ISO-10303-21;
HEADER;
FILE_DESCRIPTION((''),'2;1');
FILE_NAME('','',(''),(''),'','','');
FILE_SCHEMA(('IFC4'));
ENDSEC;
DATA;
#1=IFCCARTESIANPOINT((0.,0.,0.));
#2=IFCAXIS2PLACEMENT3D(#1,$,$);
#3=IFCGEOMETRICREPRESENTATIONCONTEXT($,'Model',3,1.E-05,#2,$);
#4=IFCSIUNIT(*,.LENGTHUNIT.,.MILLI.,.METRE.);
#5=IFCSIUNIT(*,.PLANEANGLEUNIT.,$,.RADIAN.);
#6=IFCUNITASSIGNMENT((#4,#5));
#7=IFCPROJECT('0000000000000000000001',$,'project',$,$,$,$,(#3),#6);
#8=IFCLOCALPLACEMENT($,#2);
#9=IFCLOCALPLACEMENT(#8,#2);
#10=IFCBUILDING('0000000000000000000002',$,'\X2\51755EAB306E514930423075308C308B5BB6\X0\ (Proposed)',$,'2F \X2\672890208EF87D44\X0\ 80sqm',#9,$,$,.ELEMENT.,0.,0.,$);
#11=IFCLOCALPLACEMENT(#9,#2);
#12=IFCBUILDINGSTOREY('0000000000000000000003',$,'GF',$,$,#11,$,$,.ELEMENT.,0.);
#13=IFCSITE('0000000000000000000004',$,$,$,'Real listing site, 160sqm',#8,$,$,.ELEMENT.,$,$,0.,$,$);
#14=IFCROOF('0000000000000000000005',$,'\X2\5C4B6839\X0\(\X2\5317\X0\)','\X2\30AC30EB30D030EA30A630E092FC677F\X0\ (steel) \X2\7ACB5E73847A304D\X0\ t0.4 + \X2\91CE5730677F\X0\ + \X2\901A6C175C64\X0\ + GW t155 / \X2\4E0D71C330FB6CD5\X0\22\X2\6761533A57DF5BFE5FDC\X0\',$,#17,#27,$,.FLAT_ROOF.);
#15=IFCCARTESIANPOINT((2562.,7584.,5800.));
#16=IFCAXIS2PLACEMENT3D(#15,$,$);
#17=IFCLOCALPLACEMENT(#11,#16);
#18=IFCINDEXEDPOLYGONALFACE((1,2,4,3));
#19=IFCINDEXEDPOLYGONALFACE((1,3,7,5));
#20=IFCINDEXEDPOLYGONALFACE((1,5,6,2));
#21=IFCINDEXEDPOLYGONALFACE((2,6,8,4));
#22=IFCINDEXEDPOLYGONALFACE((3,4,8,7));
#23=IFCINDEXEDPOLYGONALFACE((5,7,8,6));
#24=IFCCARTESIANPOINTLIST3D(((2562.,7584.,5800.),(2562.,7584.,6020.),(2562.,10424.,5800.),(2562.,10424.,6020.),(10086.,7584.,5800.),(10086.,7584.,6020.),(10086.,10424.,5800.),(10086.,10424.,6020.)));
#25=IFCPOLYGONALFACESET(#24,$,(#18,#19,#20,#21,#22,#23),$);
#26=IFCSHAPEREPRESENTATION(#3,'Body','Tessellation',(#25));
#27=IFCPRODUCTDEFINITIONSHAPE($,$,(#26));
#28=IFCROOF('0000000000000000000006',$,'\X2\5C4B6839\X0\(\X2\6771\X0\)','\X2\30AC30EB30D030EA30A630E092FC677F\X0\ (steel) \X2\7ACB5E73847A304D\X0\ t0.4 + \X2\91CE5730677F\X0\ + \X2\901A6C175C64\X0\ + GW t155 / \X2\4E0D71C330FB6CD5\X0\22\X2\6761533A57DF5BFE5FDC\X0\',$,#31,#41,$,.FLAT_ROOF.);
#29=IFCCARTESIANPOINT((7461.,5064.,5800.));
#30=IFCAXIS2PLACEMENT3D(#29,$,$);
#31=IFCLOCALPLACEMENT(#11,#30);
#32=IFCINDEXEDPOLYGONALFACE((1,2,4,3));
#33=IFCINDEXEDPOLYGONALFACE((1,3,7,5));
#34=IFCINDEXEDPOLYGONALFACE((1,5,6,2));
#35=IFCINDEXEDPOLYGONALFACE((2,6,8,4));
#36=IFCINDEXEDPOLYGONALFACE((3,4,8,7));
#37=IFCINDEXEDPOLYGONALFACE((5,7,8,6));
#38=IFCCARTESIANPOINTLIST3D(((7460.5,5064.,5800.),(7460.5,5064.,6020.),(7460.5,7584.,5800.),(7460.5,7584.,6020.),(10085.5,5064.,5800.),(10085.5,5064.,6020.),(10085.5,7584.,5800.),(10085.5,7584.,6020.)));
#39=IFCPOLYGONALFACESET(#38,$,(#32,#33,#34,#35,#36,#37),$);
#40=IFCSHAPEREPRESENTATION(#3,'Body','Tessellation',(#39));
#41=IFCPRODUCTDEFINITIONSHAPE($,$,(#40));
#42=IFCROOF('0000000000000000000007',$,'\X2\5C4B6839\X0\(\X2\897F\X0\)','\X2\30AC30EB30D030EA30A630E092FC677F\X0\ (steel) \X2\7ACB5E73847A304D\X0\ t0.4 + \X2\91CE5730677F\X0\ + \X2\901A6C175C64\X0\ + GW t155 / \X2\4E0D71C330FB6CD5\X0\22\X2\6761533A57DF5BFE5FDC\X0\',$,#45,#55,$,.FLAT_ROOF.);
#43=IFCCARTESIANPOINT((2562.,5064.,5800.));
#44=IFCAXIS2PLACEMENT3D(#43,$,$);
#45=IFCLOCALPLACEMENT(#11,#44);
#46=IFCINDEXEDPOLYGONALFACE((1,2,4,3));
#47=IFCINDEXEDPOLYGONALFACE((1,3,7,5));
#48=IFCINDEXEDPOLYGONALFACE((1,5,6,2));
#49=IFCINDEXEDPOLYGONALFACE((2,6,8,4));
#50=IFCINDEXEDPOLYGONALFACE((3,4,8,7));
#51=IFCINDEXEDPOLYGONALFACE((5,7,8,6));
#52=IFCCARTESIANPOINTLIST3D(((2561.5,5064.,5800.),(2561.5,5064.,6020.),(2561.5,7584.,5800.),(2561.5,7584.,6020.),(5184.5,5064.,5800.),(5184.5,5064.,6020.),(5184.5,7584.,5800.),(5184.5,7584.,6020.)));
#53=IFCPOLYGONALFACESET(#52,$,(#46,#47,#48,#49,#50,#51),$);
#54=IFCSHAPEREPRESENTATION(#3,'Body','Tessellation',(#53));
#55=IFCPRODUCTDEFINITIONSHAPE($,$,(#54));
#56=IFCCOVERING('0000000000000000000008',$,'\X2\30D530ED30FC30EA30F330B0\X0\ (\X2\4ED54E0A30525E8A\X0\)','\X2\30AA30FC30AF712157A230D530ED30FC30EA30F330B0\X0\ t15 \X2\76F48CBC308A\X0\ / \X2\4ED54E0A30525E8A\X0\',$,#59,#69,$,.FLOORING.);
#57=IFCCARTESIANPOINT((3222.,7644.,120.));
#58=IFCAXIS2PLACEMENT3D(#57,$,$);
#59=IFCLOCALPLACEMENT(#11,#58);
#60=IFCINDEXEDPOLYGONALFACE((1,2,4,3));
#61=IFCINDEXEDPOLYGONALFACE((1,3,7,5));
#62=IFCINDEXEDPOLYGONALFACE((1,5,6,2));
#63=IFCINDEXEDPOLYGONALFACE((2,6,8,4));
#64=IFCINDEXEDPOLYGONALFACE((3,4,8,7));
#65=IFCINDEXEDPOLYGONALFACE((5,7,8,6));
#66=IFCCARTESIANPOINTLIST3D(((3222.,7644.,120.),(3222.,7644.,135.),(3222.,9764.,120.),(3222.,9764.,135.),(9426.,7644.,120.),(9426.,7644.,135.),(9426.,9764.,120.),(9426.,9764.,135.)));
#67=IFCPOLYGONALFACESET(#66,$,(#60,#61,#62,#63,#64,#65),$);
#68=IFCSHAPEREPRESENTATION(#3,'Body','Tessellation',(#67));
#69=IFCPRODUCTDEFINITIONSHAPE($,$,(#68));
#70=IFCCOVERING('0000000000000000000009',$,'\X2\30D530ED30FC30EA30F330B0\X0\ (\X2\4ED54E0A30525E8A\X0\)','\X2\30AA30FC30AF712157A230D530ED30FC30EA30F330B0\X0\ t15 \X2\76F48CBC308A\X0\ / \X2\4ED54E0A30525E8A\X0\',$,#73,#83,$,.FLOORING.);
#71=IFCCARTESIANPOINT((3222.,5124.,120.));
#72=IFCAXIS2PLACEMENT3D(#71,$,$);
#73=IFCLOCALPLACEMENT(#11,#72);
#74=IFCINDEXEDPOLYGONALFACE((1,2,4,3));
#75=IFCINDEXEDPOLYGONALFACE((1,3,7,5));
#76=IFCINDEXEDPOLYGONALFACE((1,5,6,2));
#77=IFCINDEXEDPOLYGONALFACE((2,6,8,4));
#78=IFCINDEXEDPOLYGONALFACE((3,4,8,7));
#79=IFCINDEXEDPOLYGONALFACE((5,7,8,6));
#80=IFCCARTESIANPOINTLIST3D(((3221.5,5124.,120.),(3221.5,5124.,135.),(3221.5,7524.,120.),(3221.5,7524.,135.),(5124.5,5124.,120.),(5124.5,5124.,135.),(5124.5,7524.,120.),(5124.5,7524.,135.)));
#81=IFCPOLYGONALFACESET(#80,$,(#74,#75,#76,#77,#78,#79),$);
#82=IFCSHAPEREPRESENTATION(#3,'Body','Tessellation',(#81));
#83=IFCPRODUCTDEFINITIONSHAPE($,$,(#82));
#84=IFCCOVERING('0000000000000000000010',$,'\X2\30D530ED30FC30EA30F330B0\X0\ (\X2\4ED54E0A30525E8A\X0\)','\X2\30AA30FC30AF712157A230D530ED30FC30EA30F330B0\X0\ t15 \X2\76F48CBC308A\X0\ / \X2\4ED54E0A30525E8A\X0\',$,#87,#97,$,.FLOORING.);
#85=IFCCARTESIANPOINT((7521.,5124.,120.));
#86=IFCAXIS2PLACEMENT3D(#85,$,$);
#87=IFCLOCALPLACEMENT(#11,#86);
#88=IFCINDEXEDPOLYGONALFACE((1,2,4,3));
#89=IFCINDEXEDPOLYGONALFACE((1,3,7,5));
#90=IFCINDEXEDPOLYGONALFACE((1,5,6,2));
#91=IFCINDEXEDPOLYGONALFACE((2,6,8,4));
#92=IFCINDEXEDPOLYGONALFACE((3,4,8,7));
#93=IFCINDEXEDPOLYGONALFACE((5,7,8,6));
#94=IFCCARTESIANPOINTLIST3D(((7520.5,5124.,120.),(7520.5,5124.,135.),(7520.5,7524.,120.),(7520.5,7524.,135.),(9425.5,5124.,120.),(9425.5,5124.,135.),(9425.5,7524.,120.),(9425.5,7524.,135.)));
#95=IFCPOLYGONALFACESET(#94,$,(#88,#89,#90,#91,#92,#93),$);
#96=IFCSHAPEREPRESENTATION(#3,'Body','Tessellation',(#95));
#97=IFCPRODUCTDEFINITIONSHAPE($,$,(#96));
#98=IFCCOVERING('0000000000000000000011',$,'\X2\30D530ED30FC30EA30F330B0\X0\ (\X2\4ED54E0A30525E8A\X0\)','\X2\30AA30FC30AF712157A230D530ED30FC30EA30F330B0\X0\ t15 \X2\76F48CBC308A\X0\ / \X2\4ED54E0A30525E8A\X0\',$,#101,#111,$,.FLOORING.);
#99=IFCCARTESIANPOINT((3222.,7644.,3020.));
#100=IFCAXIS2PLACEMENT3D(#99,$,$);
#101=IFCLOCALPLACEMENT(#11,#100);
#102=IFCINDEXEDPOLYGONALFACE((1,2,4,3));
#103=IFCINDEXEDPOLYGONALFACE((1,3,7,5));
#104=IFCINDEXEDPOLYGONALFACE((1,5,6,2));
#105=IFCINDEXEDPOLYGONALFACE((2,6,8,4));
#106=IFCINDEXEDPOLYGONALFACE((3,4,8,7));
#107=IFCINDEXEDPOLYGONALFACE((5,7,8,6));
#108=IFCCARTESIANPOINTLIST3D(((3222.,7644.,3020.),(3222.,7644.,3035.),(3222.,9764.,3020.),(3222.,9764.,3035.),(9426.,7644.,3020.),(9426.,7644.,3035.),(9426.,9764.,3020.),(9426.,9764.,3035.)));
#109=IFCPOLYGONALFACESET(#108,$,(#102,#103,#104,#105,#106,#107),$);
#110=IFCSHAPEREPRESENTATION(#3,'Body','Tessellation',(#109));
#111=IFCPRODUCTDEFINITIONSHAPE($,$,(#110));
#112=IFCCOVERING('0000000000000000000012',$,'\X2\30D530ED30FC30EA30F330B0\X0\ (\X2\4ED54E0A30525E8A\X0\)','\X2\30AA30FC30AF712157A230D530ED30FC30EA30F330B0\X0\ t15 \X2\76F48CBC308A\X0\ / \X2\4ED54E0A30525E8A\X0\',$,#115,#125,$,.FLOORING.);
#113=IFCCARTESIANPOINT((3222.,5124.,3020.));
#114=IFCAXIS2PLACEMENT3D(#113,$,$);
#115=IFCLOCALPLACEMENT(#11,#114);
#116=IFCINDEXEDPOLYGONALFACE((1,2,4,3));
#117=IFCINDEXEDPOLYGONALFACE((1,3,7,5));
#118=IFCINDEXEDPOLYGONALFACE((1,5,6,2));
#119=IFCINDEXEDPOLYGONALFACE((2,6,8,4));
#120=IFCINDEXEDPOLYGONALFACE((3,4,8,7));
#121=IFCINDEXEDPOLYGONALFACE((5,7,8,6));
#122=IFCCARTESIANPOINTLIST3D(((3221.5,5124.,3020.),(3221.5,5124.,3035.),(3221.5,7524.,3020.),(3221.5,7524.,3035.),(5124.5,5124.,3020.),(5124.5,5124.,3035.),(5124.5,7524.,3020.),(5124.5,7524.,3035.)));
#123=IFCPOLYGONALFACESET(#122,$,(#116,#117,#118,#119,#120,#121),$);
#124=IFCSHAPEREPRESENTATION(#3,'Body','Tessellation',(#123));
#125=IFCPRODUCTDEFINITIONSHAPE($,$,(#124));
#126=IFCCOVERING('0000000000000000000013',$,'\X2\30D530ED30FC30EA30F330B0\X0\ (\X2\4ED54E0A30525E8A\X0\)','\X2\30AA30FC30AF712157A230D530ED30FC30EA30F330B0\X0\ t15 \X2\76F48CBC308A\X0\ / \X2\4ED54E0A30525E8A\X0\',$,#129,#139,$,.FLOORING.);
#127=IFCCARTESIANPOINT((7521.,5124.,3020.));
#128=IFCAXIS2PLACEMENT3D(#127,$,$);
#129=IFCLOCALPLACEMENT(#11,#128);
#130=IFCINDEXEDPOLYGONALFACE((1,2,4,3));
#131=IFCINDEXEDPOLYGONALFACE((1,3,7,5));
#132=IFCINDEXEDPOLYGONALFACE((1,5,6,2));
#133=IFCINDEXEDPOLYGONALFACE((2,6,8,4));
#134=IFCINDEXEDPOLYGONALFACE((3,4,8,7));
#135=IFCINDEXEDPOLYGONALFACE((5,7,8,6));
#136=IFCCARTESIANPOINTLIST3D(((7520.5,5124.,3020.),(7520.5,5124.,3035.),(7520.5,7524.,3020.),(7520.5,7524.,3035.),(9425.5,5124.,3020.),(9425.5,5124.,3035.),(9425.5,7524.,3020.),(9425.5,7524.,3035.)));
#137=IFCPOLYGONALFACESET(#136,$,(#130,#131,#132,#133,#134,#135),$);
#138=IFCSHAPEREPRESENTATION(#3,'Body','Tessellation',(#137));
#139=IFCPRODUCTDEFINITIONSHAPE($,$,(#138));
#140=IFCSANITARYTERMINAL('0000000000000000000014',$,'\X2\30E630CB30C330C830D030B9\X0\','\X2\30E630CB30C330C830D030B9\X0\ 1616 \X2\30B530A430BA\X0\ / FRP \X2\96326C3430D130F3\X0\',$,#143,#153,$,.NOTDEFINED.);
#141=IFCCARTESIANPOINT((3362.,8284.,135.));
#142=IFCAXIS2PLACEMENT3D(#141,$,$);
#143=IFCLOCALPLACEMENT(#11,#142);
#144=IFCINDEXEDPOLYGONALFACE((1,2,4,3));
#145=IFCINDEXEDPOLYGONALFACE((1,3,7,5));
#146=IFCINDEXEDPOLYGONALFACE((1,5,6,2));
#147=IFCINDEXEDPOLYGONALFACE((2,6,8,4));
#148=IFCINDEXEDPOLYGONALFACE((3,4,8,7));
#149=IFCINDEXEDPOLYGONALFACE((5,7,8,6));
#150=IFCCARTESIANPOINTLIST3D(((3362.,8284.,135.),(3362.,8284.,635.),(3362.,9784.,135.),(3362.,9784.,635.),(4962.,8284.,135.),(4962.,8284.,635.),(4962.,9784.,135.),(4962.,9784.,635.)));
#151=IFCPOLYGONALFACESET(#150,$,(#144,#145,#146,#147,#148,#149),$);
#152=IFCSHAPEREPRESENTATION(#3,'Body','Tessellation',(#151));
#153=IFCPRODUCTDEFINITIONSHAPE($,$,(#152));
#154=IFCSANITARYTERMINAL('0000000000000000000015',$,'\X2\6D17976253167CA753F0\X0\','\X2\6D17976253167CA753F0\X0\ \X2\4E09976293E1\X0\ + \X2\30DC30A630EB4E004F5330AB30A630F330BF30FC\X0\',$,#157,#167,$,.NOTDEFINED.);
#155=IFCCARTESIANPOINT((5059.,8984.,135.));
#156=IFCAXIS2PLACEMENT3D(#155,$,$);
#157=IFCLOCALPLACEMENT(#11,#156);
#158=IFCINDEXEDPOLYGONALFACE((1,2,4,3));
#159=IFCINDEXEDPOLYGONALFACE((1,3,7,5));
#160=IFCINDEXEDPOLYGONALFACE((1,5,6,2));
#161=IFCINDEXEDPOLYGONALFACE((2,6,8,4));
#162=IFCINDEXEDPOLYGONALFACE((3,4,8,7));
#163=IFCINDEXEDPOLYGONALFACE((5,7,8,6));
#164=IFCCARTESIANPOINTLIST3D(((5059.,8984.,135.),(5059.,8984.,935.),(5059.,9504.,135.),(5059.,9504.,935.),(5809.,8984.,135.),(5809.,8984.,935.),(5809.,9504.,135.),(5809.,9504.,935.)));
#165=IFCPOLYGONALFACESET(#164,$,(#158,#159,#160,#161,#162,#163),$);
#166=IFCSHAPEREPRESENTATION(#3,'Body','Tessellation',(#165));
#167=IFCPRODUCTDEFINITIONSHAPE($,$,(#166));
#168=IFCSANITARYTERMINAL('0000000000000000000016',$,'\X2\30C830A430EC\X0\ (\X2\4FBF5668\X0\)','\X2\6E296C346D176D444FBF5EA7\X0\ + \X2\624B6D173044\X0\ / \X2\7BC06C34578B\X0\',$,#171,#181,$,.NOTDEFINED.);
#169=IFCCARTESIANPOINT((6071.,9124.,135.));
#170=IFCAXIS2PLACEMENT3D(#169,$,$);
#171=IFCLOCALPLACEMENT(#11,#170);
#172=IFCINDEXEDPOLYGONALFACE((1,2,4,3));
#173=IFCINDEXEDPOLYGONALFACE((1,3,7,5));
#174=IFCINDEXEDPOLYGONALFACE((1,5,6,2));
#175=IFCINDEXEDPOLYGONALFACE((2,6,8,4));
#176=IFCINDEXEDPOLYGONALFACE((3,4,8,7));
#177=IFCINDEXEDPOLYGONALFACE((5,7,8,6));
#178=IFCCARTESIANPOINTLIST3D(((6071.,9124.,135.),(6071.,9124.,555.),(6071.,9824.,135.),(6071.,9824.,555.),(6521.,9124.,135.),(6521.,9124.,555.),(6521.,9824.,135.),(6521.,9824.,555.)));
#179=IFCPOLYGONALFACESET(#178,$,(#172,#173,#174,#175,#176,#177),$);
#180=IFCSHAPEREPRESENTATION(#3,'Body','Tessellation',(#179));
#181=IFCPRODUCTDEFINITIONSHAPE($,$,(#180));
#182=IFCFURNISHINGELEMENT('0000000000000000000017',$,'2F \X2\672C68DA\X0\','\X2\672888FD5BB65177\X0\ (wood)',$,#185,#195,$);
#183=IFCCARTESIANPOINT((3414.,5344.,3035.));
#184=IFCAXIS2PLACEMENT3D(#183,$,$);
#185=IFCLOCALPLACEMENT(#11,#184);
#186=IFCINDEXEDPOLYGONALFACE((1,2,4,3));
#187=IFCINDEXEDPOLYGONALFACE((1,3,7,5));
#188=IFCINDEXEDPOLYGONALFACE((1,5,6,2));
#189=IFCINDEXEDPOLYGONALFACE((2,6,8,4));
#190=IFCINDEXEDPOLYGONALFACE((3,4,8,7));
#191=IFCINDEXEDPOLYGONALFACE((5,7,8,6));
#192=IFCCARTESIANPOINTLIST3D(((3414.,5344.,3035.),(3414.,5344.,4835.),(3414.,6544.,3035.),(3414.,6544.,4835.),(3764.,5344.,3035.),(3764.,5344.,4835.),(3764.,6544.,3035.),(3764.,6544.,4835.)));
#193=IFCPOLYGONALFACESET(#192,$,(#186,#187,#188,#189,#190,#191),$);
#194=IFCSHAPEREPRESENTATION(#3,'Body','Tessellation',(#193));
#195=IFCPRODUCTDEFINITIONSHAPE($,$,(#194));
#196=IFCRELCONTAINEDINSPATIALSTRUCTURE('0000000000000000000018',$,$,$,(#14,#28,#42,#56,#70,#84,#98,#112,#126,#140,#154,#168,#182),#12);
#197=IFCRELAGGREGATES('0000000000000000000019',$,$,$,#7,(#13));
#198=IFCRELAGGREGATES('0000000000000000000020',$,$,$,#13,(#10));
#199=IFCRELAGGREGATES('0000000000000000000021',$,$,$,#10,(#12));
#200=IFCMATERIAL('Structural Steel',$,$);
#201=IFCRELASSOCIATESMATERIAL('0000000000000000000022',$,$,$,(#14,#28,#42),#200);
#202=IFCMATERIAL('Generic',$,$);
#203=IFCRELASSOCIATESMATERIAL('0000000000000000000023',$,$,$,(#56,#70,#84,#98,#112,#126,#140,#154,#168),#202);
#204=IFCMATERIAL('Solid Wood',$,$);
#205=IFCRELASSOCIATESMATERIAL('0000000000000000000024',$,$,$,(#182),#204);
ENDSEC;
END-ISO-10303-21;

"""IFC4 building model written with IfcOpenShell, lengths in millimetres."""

from ifc_helpers import new_model, si_unit, frame, frame_2d, origin, place, context, project, spatial, rectangle, extrude, material, element, save


model = new_model("IFC4")

# Units and contexts
model_context = context("Model", 3, precision=1e-05, world=origin())
ifc_project = project(units=[si_unit("LENGTHUNIT", "METRE", prefix="MILLI"), si_unit("PLANEANGLEUNIT", "RADIAN")], contexts=[model_context])

# Site, building, storey
site_placement = place(None, origin())
site = spatial("IfcSite", under=ifc_project, at=site_placement, ObjectType="Real listing site, 160sqm", CompositionType="ELEMENT", RefElevation=0.0)
building_placement = place(site_placement, origin())
building = spatial("IfcBuilding", under=site, at=building_placement, Name="兵庫の光あふれる家 (Proposed)", ObjectType="2F 木造軸組 80sqm", CompositionType="ELEMENT", ElevationOfRefHeight=0.0, ElevationOfTerrain=0.0)
storey_placement = place(building_placement, origin())
storey = spatial("IfcBuildingStorey", under=building, at=storey_placement, Name="GF", CompositionType="ELEMENT", Elevation=0.0)

# Shared definitions
ifc_material_1 = material(Name="Solid Wood")

# Roofs
ifc_material_2 = material(Name="Structural Steel")
roof_1_placement = place(storey_placement, frame((2562.0, 7584.0, 5800.0)))
element("IfcRoof", 1, at=roof_1_placement, inside=storey, material=ifc_material_2, Name="屋根(北)", Description="ガルバリウム鋼板 (steel) 立平葺き t0.4 + 野地板 + 通気層 + GW t155 / 不燃・法22条区域対応", PredefinedType="FLAT_ROOF", context=model_context, shape_type="SweptSolid", body=[
    extrude(rectangle(XDim=7524.0, YDim=2840.0, at=frame_2d((3762.0, 1420.0))), frame((2562.0, 7584.0, 5800.0)), (0.0, 0.0, 1.0), 220.0),
])
roof_2_placement = place(storey_placement, frame((7461.0, 5064.0, 5800.0)))
element("IfcRoof", 2, at=roof_2_placement, inside=storey, material=ifc_material_2, Name="屋根(東)", Description="ガルバリウム鋼板 (steel) 立平葺き t0.4 + 野地板 + 通気層 + GW t155 / 不燃・法22条区域対応", PredefinedType="FLAT_ROOF", context=model_context, shape_type="SweptSolid", body=[
    extrude(rectangle(XDim=2625.0, YDim=2520.0, at=frame_2d((1312.0, 1260.0))), frame((7461.0, 5064.0, 5800.0)), (0.0, 0.0, 1.0), 220.0),
])
roof_3_placement = place(storey_placement, frame((2562.0, 5064.0, 5800.0)))
element("IfcRoof", 3, at=roof_3_placement, inside=storey, material=ifc_material_2, Name="屋根(西)", Description="ガルバリウム鋼板 (steel) 立平葺き t0.4 + 野地板 + 通気層 + GW t155 / 不燃・法22条区域対応", PredefinedType="FLAT_ROOF", context=model_context, shape_type="SweptSolid", body=[
    extrude(rectangle(XDim=2623.0, YDim=2520.0, at=frame_2d((1311.0, 1260.0))), frame((2562.0, 5064.0, 5800.0)), (0.0, 0.0, 1.0), 220.0),
])

# Coverings
ifc_material_3 = material(Name="Generic")
covering_1_placement = place(storey_placement, frame((3222.0, 7644.0, 120.0)))
element("IfcCovering", 4, at=covering_1_placement, inside=storey, material=ifc_material_3, Name="フローリング (仕上げ床)", Description="オーク無垢フローリング t15 直貼り / 仕上げ床", PredefinedType="FLOORING", context=model_context, shape_type="SweptSolid", body=[
    extrude(rectangle(XDim=6204.0, YDim=2120.0, at=frame_2d((3102.0, 1060.0))), frame((3222.0, 7644.0, 120.0)), (0.0, 0.0, 1.0), 15.0),
])
covering_2_placement = place(storey_placement, frame((3222.0, 5124.0, 120.0)))
element("IfcCovering", 5, at=covering_2_placement, inside=storey, material=ifc_material_3, Name="フローリング (仕上げ床)", Description="オーク無垢フローリング t15 直貼り / 仕上げ床", PredefinedType="FLOORING", context=model_context, shape_type="SweptSolid", body=[
    extrude(rectangle(XDim=1903.0, YDim=2400.0, at=frame_2d((951.0, 1200.0))), frame((3222.0, 5124.0, 120.0)), (0.0, 0.0, 1.0), 15.0),
])
covering_3_placement = place(storey_placement, frame((7521.0, 5124.0, 120.0)))
element("IfcCovering", 6, at=covering_3_placement, inside=storey, material=ifc_material_3, Name="フローリング (仕上げ床)", Description="オーク無垢フローリング t15 直貼り / 仕上げ床", PredefinedType="FLOORING", context=model_context, shape_type="SweptSolid", body=[
    extrude(rectangle(XDim=1905.0, YDim=2400.0, at=frame_2d((952.0, 1200.0))), frame((7521.0, 5124.0, 120.0)), (0.0, 0.0, 1.0), 15.0),
])
covering_4_placement = place(storey_placement, frame((3222.0, 7644.0, 3020.0)))
element("IfcCovering", 7, at=covering_4_placement, inside=storey, material=ifc_material_3, Name="フローリング (仕上げ床)", Description="オーク無垢フローリング t15 直貼り / 仕上げ床", PredefinedType="FLOORING", context=model_context, shape_type="SweptSolid", body=[
    extrude(rectangle(XDim=6204.0, YDim=2120.0, at=frame_2d((3102.0, 1060.0))), frame((3222.0, 7644.0, 3020.0)), (0.0, 0.0, 1.0), 15.0),
])
covering_5_placement = place(storey_placement, frame((3222.0, 5124.0, 3020.0)))
element("IfcCovering", 8, at=covering_5_placement, inside=storey, material=ifc_material_3, Name="フローリング (仕上げ床)", Description="オーク無垢フローリング t15 直貼り / 仕上げ床", PredefinedType="FLOORING", context=model_context, shape_type="SweptSolid", body=[
    extrude(rectangle(XDim=1903.0, YDim=2400.0, at=frame_2d((951.0, 1200.0))), frame((3222.0, 5124.0, 3020.0)), (0.0, 0.0, 1.0), 15.0),
])
covering_6_placement = place(storey_placement, frame((7521.0, 5124.0, 3020.0)))
element("IfcCovering", 9, at=covering_6_placement, inside=storey, material=ifc_material_3, Name="フローリング (仕上げ床)", Description="オーク無垢フローリング t15 直貼り / 仕上げ床", PredefinedType="FLOORING", context=model_context, shape_type="SweptSolid", body=[
    extrude(rectangle(XDim=1905.0, YDim=2400.0, at=frame_2d((952.0, 1200.0))), frame((7521.0, 5124.0, 3020.0)), (0.0, 0.0, 1.0), 15.0),
])

# Sanitary terminals
sanitary_terminal_1_placement = place(storey_placement, frame((3362.0, 8284.0, 135.0)))
element("IfcSanitaryTerminal", 10, at=sanitary_terminal_1_placement, inside=storey, material=ifc_material_3, Name="ユニットバス", Description="ユニットバス 1616 サイズ / FRP 防水パン", PredefinedType="NOTDEFINED", context=model_context, shape_type="SweptSolid", body=[
    extrude(rectangle(XDim=1600.0, YDim=1500.0, at=frame_2d((800.0, 750.0))), frame((3362.0, 8284.0, 135.0)), (0.0, 0.0, 1.0), 500.0),
])
sanitary_terminal_2_placement = place(storey_placement, frame((5059.0, 8984.0, 135.0)))
element("IfcSanitaryTerminal", 11, at=sanitary_terminal_2_placement, inside=storey, material=ifc_material_3, Name="洗面化粧台", Description="洗面化粧台 三面鏡 + ボウル一体カウンター", PredefinedType="NOTDEFINED", context=model_context, shape_type="SweptSolid", body=[
    extrude(rectangle(XDim=750.0, YDim=520.0, at=frame_2d((375.0, 260.0))), frame((5059.0, 8984.0, 135.0)), (0.0, 0.0, 1.0), 800.0),
])
sanitary_terminal_3_placement = place(storey_placement, frame((6071.0, 9124.0, 135.0)))
element("IfcSanitaryTerminal", 12, at=sanitary_terminal_3_placement, inside=storey, material=ifc_material_3, Name="トイレ (便器)", Description="温水洗浄便座 + 手洗い / 節水型", PredefinedType="NOTDEFINED", context=model_context, shape_type="SweptSolid", body=[
    extrude(rectangle(XDim=450.0, YDim=700.0, at=frame_2d((225.0, 350.0))), frame((6071.0, 9124.0, 135.0)), (0.0, 0.0, 1.0), 420.0),
])

# Furnishing element
furnishing_placement = place(storey_placement, frame((3414.0, 5344.0, 3035.0)))
element("IfcFurnishingElement", 13, at=furnishing_placement, inside=storey, material=ifc_material_1, Name="2F 本棚", Description="木製家具 (wood)", context=model_context, shape_type="SweptSolid", body=[
    extrude(rectangle(XDim=350.0, YDim=1200.0, at=frame_2d((175.0, 600.0))), frame((3414.0, 5344.0, 3035.0)), (0.0, 0.0, 1.0), 1800.0),
])

save(model, "model.ifc")
